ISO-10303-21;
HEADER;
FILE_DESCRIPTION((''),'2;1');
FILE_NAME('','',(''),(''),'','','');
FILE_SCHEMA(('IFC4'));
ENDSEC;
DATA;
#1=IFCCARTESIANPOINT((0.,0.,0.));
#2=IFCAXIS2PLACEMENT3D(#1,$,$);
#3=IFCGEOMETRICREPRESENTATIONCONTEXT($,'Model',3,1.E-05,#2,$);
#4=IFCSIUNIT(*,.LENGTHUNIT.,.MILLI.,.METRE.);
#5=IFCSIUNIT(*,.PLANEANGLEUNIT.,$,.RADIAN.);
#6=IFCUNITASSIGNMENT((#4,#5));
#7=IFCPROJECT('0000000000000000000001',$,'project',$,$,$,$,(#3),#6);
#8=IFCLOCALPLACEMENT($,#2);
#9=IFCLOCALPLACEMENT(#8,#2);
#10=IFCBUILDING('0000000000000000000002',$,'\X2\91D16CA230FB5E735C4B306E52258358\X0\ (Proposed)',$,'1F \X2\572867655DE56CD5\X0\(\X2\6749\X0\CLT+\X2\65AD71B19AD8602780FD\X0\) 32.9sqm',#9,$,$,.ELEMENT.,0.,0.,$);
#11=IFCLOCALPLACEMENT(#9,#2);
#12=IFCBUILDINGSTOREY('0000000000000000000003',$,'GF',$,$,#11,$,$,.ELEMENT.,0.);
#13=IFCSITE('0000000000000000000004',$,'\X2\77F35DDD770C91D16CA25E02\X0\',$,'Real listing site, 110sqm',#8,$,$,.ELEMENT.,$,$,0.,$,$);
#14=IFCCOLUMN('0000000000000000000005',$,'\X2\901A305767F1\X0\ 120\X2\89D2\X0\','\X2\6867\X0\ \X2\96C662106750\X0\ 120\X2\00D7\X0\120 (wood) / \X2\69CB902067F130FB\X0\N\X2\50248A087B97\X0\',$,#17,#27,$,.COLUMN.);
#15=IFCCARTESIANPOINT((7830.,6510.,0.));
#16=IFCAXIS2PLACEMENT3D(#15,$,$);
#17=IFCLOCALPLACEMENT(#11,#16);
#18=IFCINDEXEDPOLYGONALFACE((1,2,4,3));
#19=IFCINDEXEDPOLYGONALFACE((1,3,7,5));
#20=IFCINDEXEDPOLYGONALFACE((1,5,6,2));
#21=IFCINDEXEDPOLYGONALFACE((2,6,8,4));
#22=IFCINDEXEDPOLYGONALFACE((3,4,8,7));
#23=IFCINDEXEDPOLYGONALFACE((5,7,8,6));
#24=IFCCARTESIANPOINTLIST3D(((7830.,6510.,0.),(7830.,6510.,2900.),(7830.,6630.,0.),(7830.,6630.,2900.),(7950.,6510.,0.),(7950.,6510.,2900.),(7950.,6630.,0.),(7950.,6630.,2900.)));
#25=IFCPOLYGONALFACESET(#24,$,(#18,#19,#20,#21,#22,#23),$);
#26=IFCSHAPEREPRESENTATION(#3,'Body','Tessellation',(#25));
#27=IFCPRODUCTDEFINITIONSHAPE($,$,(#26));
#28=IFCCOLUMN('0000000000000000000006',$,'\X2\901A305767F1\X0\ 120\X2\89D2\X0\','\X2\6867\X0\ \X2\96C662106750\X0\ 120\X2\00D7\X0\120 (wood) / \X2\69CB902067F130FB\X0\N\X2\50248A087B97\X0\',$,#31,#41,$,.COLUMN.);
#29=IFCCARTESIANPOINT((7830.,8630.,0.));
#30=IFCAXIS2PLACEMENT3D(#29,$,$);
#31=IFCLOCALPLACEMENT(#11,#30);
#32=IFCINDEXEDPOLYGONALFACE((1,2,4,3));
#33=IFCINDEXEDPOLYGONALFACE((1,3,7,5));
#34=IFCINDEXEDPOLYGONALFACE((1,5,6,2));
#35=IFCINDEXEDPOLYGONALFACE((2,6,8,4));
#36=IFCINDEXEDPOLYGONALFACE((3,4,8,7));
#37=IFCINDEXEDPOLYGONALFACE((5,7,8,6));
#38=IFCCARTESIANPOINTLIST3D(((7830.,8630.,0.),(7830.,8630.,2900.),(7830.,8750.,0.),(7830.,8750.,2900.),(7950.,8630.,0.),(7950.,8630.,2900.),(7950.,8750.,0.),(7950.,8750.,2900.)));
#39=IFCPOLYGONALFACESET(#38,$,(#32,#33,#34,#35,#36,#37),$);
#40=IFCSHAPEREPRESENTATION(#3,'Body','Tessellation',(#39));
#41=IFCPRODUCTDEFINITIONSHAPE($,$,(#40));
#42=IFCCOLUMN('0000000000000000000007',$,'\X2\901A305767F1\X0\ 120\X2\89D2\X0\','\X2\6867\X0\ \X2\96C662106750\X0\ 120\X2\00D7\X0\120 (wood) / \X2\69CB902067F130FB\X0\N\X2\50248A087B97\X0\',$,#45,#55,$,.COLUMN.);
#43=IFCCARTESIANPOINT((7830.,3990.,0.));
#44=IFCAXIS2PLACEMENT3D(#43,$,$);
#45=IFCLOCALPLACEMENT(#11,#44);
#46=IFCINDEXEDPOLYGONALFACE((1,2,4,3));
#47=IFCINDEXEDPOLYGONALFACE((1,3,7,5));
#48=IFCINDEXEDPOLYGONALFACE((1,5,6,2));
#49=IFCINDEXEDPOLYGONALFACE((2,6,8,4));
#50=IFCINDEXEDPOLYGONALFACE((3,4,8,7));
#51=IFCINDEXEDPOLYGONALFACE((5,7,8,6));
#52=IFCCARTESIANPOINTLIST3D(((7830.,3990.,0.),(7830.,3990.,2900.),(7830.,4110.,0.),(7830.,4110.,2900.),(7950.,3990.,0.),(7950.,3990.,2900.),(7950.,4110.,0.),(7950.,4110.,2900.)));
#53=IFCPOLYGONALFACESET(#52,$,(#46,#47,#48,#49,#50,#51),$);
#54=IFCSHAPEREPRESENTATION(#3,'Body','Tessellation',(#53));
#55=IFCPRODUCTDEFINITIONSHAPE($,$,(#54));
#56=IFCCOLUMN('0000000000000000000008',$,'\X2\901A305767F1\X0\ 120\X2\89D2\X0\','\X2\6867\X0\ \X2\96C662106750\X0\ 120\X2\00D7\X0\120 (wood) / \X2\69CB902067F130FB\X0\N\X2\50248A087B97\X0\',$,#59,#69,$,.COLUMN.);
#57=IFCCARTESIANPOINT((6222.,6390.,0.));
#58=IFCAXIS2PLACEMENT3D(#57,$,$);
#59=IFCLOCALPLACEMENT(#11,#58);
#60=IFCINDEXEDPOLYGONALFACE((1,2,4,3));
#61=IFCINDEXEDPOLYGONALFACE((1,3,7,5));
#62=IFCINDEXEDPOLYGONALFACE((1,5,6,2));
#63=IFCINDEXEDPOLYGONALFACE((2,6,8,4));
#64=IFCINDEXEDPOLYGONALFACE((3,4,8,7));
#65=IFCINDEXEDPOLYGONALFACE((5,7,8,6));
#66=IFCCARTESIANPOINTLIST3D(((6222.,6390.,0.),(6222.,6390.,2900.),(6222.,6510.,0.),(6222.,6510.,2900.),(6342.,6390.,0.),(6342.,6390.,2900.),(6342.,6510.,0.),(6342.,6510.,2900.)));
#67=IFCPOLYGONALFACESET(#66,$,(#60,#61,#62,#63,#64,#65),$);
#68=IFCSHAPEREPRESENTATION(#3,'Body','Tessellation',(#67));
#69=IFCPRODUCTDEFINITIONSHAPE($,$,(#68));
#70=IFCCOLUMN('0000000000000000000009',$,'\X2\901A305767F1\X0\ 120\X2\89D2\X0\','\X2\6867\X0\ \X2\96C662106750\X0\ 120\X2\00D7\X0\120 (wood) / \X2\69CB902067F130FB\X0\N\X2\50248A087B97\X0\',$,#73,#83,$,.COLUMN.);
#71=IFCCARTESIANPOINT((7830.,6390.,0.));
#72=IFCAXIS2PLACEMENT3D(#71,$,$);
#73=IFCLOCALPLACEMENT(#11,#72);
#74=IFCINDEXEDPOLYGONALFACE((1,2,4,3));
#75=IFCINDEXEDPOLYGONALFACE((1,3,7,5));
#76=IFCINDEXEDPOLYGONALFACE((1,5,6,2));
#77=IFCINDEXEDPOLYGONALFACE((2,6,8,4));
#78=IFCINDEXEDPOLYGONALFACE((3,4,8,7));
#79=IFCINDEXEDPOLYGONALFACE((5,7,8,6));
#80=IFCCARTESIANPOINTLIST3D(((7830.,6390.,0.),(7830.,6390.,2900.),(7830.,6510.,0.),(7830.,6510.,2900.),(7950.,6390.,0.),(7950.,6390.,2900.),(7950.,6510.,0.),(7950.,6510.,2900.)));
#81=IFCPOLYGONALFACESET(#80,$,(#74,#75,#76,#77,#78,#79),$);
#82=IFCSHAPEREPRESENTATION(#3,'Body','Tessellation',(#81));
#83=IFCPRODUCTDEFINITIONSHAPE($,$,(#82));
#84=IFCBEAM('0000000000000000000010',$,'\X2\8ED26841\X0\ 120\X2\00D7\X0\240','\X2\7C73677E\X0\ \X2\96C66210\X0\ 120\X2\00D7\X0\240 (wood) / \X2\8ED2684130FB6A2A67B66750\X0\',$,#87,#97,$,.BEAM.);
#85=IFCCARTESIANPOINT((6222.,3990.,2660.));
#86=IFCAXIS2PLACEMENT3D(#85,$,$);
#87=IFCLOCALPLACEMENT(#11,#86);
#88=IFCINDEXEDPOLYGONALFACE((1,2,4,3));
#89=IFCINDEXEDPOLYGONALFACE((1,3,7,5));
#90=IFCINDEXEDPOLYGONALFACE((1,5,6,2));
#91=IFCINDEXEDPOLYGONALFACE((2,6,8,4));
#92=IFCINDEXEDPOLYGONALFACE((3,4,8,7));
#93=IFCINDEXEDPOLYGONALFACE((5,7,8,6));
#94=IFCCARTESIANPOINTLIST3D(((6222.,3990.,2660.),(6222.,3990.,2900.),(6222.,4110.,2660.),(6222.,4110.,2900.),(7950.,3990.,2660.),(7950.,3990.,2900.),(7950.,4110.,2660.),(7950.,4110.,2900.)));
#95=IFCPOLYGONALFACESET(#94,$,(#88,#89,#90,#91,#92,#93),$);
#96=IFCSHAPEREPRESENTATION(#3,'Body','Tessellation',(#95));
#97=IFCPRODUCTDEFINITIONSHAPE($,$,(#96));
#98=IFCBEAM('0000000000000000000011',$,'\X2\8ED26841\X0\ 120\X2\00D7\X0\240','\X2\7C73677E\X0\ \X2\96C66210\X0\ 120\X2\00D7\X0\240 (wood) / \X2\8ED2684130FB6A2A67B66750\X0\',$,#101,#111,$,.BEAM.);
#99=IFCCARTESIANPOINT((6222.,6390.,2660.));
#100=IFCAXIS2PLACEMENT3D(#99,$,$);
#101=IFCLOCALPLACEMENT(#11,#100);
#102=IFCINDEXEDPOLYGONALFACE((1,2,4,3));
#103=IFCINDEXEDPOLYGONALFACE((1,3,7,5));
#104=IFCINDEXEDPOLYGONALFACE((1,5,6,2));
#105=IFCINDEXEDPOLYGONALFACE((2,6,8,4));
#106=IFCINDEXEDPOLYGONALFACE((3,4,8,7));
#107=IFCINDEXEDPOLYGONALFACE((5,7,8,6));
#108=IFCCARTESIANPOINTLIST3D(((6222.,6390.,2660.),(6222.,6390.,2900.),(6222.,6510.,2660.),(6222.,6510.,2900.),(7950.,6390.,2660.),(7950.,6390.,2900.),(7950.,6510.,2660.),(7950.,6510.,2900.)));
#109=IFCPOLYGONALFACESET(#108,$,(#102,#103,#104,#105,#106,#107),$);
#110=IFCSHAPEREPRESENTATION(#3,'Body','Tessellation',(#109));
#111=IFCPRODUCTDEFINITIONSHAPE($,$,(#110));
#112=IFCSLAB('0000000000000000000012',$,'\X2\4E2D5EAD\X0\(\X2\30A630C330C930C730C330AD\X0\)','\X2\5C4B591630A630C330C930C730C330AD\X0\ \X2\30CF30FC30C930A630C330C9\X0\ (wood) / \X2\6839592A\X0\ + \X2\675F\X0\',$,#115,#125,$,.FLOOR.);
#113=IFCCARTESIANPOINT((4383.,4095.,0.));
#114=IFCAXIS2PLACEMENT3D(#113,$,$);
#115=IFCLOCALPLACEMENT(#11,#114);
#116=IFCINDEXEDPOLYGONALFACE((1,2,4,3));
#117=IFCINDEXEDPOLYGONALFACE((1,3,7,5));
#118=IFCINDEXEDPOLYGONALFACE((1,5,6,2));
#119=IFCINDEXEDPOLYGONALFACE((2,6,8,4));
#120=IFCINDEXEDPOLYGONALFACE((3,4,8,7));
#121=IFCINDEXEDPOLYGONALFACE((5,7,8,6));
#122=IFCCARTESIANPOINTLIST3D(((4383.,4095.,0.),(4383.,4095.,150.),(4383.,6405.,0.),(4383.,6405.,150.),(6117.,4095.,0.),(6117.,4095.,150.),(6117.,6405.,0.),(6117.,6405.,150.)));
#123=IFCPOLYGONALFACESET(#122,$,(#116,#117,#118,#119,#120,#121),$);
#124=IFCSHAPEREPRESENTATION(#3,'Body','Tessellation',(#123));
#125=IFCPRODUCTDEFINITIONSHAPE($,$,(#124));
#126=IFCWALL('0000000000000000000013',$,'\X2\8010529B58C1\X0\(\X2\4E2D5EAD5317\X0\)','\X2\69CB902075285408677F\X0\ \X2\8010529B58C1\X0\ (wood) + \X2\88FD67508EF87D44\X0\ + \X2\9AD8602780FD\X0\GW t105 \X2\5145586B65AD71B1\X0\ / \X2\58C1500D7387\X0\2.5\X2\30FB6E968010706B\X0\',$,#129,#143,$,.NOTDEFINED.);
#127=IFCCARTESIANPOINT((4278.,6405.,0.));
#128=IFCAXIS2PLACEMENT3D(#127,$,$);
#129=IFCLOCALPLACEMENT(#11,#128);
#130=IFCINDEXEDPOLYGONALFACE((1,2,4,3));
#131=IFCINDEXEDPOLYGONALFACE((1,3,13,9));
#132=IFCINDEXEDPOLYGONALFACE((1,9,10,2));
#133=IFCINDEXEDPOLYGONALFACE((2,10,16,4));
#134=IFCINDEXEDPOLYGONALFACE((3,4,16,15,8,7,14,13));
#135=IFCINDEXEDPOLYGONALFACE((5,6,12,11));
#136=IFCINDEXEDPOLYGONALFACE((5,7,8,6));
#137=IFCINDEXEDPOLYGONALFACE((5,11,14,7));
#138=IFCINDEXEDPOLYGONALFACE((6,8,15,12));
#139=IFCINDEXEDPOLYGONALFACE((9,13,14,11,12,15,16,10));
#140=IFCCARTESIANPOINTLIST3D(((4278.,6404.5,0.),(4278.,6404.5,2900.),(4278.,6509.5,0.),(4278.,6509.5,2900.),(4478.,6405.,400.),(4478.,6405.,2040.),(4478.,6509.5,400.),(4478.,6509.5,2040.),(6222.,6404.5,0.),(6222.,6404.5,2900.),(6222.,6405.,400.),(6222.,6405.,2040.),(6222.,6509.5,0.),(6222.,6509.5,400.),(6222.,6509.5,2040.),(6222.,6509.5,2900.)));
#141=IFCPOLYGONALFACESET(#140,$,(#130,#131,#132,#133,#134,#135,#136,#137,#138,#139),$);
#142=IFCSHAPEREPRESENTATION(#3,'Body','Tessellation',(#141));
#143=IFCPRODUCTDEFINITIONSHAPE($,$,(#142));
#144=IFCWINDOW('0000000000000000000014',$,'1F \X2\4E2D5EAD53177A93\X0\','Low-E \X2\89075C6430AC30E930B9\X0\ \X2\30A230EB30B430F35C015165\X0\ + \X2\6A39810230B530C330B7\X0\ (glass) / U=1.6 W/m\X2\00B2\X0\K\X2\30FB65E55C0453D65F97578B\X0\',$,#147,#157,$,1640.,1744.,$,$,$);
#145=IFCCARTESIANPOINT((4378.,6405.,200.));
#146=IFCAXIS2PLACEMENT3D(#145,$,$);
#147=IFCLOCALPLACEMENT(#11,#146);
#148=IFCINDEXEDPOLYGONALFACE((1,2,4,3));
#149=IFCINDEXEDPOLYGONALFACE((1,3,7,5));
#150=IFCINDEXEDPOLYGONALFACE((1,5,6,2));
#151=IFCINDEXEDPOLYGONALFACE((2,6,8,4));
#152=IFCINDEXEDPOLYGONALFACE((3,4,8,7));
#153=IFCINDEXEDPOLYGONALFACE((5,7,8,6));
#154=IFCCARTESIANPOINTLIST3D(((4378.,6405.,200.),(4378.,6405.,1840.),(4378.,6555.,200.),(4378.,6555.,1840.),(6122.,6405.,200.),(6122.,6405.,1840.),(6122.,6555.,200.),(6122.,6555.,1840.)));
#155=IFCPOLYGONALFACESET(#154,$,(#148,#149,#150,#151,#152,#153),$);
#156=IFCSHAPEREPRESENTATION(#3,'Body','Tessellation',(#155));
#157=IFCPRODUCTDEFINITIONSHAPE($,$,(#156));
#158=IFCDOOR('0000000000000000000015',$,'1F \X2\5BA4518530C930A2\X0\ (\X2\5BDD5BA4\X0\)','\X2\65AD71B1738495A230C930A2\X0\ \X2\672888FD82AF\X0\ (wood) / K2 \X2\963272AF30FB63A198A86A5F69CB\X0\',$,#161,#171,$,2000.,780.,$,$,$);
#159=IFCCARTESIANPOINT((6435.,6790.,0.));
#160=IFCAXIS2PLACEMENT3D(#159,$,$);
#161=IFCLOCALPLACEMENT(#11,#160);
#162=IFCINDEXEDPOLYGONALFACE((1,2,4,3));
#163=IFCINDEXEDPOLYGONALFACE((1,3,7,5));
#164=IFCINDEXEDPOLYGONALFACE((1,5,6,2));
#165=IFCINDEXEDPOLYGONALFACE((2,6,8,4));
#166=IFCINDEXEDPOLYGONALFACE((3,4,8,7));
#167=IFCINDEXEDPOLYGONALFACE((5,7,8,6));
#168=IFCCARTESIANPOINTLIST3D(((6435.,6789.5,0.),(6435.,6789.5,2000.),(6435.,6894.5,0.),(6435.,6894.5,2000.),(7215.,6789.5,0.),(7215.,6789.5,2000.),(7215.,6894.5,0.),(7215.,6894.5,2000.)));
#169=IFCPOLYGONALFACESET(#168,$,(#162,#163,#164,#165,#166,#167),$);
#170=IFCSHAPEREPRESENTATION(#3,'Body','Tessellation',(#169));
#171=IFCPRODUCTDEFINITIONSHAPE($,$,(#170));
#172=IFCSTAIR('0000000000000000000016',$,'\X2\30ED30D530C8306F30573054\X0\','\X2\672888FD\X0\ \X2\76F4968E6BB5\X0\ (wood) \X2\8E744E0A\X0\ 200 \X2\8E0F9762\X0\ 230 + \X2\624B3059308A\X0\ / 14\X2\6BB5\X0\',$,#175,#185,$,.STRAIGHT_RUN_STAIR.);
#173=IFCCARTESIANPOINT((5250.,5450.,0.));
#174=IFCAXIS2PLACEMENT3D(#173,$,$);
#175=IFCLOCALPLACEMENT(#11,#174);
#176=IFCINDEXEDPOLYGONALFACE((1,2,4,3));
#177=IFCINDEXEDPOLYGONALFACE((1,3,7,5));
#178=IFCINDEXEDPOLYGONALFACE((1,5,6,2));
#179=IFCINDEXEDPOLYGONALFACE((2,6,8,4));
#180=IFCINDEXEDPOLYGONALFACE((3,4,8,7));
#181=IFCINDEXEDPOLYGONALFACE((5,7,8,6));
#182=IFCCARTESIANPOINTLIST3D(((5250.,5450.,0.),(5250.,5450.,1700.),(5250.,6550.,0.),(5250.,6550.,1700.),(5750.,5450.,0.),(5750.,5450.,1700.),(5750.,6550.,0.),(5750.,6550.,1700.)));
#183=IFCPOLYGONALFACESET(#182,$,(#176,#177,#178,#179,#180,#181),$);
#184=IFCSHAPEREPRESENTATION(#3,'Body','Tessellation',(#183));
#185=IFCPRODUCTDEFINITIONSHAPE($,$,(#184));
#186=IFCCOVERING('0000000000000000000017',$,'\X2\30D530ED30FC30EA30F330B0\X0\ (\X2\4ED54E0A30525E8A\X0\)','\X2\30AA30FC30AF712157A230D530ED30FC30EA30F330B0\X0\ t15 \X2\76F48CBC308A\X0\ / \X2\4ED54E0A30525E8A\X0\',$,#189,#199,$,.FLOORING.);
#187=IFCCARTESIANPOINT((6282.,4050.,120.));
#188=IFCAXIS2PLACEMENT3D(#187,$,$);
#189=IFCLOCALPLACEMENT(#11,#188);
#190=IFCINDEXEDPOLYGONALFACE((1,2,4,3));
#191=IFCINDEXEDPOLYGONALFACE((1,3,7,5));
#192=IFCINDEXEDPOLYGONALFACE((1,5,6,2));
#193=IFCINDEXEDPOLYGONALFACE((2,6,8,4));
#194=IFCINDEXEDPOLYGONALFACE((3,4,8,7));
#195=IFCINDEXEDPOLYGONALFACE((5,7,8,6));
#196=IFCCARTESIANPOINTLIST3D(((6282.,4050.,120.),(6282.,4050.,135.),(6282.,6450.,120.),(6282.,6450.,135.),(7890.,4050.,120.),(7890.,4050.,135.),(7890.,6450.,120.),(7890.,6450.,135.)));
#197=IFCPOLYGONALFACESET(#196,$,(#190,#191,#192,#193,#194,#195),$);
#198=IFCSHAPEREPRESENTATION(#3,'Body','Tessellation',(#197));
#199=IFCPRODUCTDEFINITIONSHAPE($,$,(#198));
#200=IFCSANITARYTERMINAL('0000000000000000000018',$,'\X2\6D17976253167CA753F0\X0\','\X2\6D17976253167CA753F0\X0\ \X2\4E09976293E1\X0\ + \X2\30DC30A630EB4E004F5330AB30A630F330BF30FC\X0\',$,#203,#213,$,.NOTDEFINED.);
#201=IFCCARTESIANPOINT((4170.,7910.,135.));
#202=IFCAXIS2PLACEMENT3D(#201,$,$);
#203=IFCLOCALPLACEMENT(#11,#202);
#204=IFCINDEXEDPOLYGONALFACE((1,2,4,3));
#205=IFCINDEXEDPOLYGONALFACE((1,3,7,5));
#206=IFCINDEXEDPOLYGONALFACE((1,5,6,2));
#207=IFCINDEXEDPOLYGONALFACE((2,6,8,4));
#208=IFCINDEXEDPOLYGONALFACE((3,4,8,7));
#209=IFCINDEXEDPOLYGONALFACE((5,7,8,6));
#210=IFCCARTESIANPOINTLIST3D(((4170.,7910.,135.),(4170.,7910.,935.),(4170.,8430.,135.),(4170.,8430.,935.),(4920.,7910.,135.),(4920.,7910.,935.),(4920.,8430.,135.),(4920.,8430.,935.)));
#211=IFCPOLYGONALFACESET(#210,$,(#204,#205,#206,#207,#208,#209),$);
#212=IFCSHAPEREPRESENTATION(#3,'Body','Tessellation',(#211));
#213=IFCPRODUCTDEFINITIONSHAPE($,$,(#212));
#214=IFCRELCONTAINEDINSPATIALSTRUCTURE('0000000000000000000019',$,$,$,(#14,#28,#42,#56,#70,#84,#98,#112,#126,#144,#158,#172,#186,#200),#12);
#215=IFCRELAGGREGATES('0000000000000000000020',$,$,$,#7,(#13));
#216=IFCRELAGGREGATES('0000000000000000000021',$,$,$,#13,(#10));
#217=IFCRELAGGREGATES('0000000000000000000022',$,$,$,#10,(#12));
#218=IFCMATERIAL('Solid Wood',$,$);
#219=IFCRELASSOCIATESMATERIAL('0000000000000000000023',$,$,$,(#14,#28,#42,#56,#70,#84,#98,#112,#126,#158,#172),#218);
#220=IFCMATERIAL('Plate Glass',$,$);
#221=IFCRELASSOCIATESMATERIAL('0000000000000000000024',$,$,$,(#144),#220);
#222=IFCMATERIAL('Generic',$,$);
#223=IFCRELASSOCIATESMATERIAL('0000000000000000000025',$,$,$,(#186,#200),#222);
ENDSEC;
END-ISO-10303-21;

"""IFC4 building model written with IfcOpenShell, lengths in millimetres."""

from ifc_helpers import new_model, si_unit, frame, frame_2d, origin, place, context, project, spatial, rectangle, extrude, material, element, fill, save


model = new_model("IFC4")

# Units and contexts
model_context = context("Model", 3, precision=1e-05, world=origin())
ifc_project = project(units=[si_unit("LENGTHUNIT", "METRE", prefix="MILLI"), si_unit("PLANEANGLEUNIT", "RADIAN")], contexts=[model_context])

# Site, building, storey
site_placement = place(None, origin())
site = spatial("IfcSite", under=ifc_project, at=site_placement, Name="石川県金沢市", ObjectType="Real listing site, 110sqm", CompositionType="ELEMENT", RefElevation=0.0)
building_placement = place(site_placement, origin())
building = spatial("IfcBuilding", under=site, at=building_placement, Name="金沢・平屋の別荘 (Proposed)", ObjectType="1F 在来工法(杉CLT+断熱高性能) 32.9sqm", CompositionType="ELEMENT", ElevationOfRefHeight=0.0, ElevationOfTerrain=0.0)
storey_placement = place(building_placement, origin())
storey = spatial("IfcBuildingStorey", under=building, at=storey_placement, Name="GF", CompositionType="ELEMENT", Elevation=0.0)

# Columns
ifc_material_1 = material(Name="Solid Wood")
column_1_placement = place(storey_placement, frame((7830.0, 6510.0, 0.0)))
element("IfcColumn", 1, at=column_1_placement, inside=storey, material=ifc_material_1, Name="通し柱 120角", Description="桧 集成材 120×120 (wood) / 構造柱・N値計算", PredefinedType="COLUMN", context=model_context, shape_type="SweptSolid", body=[
    extrude(rectangle(XDim=120.0, YDim=120.0, at=frame_2d((60.0, 60.0))), frame((7830.0, 6510.0, 0.0)), (0.0, 0.0, 1.0), 2900.0),
])
column_2_placement = place(storey_placement, frame((7830.0, 8630.0, 0.0)))
element("IfcColumn", 2, at=column_2_placement, inside=storey, material=ifc_material_1, Name="通し柱 120角", Description="桧 集成材 120×120 (wood) / 構造柱・N値計算", PredefinedType="COLUMN", context=model_context, shape_type="SweptSolid", body=[
    extrude(rectangle(XDim=120.0, YDim=120.0, at=frame_2d((60.0, 60.0))), frame((7830.0, 8630.0, 0.0)), (0.0, 0.0, 1.0), 2900.0),
])
column_3_placement = place(storey_placement, frame((7830.0, 3990.0, 0.0)))
element("IfcColumn", 3, at=column_3_placement, inside=storey, material=ifc_material_1, Name="通し柱 120角", Description="桧 集成材 120×120 (wood) / 構造柱・N値計算", PredefinedType="COLUMN", context=model_context, shape_type="SweptSolid", body=[
    extrude(rectangle(XDim=120.0, YDim=120.0, at=frame_2d((60.0, 60.0))), frame((7830.0, 3990.0, 0.0)), (0.0, 0.0, 1.0), 2900.0),
])
column_4_placement = place(storey_placement, frame((6222.0, 6390.0, 0.0)))
element("IfcColumn", 4, at=column_4_placement, inside=storey, material=ifc_material_1, Name="通し柱 120角", Description="桧 集成材 120×120 (wood) / 構造柱・N値計算", PredefinedType="COLUMN", context=model_context, shape_type="SweptSolid", body=[
    extrude(rectangle(XDim=120.0, YDim=120.0, at=frame_2d((60.0, 60.0))), frame((6222.0, 6390.0, 0.0)), (0.0, 0.0, 1.0), 2900.0),
])
column_5_placement = place(storey_placement, frame((7830.0, 6390.0, 0.0)))
element("IfcColumn", 5, at=column_5_placement, inside=storey, material=ifc_material_1, Name="通し柱 120角", Description="桧 集成材 120×120 (wood) / 構造柱・N値計算", PredefinedType="COLUMN", context=model_context, shape_type="SweptSolid", body=[
    extrude(rectangle(XDim=120.0, YDim=120.0, at=frame_2d((60.0, 60.0))), frame((7830.0, 6390.0, 0.0)), (0.0, 0.0, 1.0), 2900.0),
])

# Beams
beam_1_placement = place(storey_placement, frame((6222.0, 3990.0, 2660.0)))
element("IfcBeam", 6, at=beam_1_placement, inside=storey, material=ifc_material_1, Name="軒桁 120×240", Description="米松 集成 120×240 (wood) / 軒桁・横架材", PredefinedType="BEAM", context=model_context, shape_type="SweptSolid", body=[
    extrude(rectangle(XDim=1728.0, YDim=120.0, at=frame_2d((864.0, 60.0))), frame((6222.0, 3990.0, 2660.0)), (0.0, 0.0, 1.0), 240.0),
])
beam_2_placement = place(storey_placement, frame((6222.0, 6390.0, 2660.0)))
element("IfcBeam", 7, at=beam_2_placement, inside=storey, material=ifc_material_1, Name="軒桁 120×240", Description="米松 集成 120×240 (wood) / 軒桁・横架材", PredefinedType="BEAM", context=model_context, shape_type="SweptSolid", body=[
    extrude(rectangle(XDim=1728.0, YDim=120.0, at=frame_2d((864.0, 60.0))), frame((6222.0, 6390.0, 2660.0)), (0.0, 0.0, 1.0), 240.0),
])

# Slab
slab_placement = place(storey_placement, frame((4383.0, 4095.0, 0.0)))
element("IfcSlab", 8, at=slab_placement, inside=storey, material=ifc_material_1, Name="中庭(ウッドデッキ)", Description="屋外ウッドデッキ ハードウッド (wood) / 根太 + 束", PredefinedType="FLOOR", context=model_context, shape_type="SweptSolid", body=[
    extrude(rectangle(XDim=1734.0, YDim=2310.0, at=frame_2d((867.0, 1155.0))), frame((4383.0, 4095.0, 0.0)), (0.0, 0.0, 1.0), 150.0),
])

# Wall, opening, window
wall_1_placement = place(storey_placement, frame((4278.0, 6405.0, 0.0)))
wall_1 = element("IfcWall", 9, at=wall_1_placement, inside=storey, material=ifc_material_1, Name="耐力壁(中庭北)", Description="構造用合板 耐力壁 (wood) + 製材軸組 + 高性能GW t105 充填断熱 / 壁倍率2.5・準耐火", PredefinedType="NOTDEFINED", context=model_context, shape_type="SweptSolid", body=[
    extrude(rectangle(XDim=1944.0, YDim=105.0, at=frame_2d((972.0, 52.0))), frame((4278.0, 6405.0, 0.0)), (0.0, 0.0, 1.0), 2900.0),
])
opening_placement = place(storey_placement, frame((4378.0, 6405.0, 200.0)))
opening = element("IfcOpeningElement", 10, at=opening_placement, cuts=wall_1, PredefinedType="NOTDEFINED", context=model_context, shape_type="SweptSolid", body=[
    extrude(rectangle(XDim=1744.0, YDim=150.0, at=frame_2d((872.0, 75.0))), frame((4378.0, 6405.0, 200.0)), (0.0, 0.0, 1.0), 1640.0),
])
ifc_material_2 = material(Name="Plate Glass")
window_placement = place(storey_placement, frame((4378.0, 6405.0, 200.0)))
window = element("IfcWindow", 11, at=window_placement, inside=storey, material=ifc_material_2, Name="1F 中庭北窓", Description="Low-E 複層ガラス アルゴン封入 + 樹脂サッシ (glass) / U=1.6 W/m²K・日射取得型", OverallHeight=1640.0, OverallWidth=1744.0, context=model_context, shape_type="SweptSolid", body=[
    extrude(rectangle(XDim=1744.0, YDim=150.0, at=frame_2d((872.0, 75.0))), frame((4378.0, 6405.0, 200.0)), (0.0, 0.0, 1.0), 1640.0),
])
fill(opening, window)

# Door
door_placement = place(storey_placement, frame((6435.0, 6790.0, 0.0)))
element("IfcDoor", 12, at=door_placement, inside=storey, material=ifc_material_1, Name="1F 室内ドア (寝室)", Description="断熱玄関ドア 木製芯 (wood) / K2 防犯・採風機構", OverallHeight=2000.0, OverallWidth=780.0, context=model_context, shape_type="SweptSolid", body=[
    extrude(rectangle(XDim=780.0, YDim=105.0, at=frame_2d((390.0, 52.0))), frame((6435.0, 6790.0, 0.0)), (0.0, 0.0, 1.0), 2000.0),
])

# Stair
stair_placement = place(storey_placement, frame((5250.0, 5450.0, 0.0)))
element("IfcStair", 13, at=stair_placement, inside=storey, material=ifc_material_1, Name="ロフトはしご", Description="木製 直階段 (wood) 蹴上 200 踏面 230 + 手すり / 14段", PredefinedType="STRAIGHT_RUN_STAIR", context=model_context, shape_type="SweptSolid", body=[
    extrude(rectangle(XDim=500.0, YDim=1100.0, at=frame_2d((250.0, 550.0))), frame((5250.0, 5450.0, 0.0)), (0.0, 0.0, 1.0), 1700.0),
])

# Covering
ifc_material_3 = material(Name="Generic")
covering_placement = place(storey_placement, frame((6282.0, 4050.0, 120.0)))
element("IfcCovering", 14, at=covering_placement, inside=storey, material=ifc_material_3, Name="フローリング (仕上げ床)", Description="オーク無垢フローリング t15 直貼り / 仕上げ床", PredefinedType="FLOORING", context=model_context, shape_type="SweptSolid", body=[
    extrude(rectangle(XDim=1608.0, YDim=2400.0, at=frame_2d((804.0, 1200.0))), frame((6282.0, 4050.0, 120.0)), (0.0, 0.0, 1.0), 15.0),
])

# Sanitary terminal
sanitary_terminal_1_placement = place(storey_placement, frame((4170.0, 7910.0, 135.0)))
element("IfcSanitaryTerminal", 15, at=sanitary_terminal_1_placement, inside=storey, material=ifc_material_3, Name="洗面化粧台", Description="洗面化粧台 三面鏡 + ボウル一体カウンター", PredefinedType="NOTDEFINED", context=model_context, shape_type="SweptSolid", body=[
    extrude(rectangle(XDim=750.0, YDim=520.0, at=frame_2d((375.0, 260.0))), frame((4170.0, 7910.0, 135.0)), (0.0, 0.0, 1.0), 800.0),
])

save(model, "model.ifc")
